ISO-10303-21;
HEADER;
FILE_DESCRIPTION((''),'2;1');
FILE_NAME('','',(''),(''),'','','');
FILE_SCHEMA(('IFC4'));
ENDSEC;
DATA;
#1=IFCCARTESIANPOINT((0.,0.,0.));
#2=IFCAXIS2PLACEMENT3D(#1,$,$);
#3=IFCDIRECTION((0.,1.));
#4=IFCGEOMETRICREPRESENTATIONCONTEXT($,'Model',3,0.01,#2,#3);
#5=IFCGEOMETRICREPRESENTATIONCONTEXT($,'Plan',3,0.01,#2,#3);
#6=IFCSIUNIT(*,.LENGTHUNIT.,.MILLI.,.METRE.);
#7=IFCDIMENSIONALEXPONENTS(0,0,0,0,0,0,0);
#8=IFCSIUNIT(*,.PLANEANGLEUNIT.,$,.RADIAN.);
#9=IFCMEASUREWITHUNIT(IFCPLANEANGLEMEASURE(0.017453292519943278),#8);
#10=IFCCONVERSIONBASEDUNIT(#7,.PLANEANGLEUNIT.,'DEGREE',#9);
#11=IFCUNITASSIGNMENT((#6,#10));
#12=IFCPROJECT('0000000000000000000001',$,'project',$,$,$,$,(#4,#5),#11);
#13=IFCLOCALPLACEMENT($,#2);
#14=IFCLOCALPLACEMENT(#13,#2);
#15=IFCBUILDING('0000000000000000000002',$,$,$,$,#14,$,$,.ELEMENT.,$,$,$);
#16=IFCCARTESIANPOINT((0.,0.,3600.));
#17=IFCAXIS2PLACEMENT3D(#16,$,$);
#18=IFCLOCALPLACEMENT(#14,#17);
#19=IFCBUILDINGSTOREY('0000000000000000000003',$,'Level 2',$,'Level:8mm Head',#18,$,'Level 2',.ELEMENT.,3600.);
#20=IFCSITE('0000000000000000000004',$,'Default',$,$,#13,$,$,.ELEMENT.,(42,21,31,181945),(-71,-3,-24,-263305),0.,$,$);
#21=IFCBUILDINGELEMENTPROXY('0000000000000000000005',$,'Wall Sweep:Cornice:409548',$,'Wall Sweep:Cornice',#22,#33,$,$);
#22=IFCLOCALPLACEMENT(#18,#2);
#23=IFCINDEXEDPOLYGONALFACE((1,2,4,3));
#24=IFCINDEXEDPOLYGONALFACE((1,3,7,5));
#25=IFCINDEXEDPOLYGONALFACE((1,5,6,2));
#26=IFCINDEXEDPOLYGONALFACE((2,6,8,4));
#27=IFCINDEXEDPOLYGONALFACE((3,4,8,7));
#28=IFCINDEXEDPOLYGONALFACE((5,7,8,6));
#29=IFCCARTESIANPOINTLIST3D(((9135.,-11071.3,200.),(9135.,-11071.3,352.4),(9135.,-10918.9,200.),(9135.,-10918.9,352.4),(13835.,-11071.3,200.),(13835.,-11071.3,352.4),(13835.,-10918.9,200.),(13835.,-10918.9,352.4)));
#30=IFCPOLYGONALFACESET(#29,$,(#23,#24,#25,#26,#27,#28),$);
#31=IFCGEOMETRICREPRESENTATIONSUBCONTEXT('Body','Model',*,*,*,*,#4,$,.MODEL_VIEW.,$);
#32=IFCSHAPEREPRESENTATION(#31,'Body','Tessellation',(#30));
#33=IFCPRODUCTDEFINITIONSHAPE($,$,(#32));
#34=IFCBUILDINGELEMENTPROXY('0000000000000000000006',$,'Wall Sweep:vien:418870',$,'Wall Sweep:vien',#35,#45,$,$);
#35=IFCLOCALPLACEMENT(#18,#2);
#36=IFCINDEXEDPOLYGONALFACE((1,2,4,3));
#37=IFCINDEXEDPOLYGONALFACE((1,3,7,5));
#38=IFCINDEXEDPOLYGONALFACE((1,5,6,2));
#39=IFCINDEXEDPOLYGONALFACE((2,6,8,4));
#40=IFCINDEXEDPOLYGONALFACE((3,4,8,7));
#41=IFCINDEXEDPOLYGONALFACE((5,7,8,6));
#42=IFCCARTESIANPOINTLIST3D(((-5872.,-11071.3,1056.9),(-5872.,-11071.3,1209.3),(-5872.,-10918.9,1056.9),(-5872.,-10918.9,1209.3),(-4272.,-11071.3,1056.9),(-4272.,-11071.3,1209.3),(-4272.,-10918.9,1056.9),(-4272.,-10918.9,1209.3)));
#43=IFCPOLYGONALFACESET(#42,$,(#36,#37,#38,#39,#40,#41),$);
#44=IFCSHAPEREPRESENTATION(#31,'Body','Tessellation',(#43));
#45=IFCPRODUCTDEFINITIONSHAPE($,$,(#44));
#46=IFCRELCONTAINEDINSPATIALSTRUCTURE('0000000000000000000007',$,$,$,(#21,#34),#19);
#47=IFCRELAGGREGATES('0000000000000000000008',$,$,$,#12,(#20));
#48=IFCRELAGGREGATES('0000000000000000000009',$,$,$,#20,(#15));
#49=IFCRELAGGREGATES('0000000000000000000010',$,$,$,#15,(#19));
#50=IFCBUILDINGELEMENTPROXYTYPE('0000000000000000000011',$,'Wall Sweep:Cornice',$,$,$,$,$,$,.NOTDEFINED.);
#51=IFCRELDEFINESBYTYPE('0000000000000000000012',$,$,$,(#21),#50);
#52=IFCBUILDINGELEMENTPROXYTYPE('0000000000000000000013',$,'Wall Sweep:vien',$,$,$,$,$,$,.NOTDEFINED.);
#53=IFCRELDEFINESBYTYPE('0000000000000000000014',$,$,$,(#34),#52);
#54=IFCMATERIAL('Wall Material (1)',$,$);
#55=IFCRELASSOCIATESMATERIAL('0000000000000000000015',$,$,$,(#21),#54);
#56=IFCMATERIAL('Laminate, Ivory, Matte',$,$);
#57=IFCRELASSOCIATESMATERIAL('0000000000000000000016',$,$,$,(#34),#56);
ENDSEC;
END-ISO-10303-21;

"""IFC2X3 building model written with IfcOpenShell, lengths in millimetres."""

from ifc_helpers import new_model, entity, si_unit, converted_unit, direction, frame, frame_2d, origin, origin_2d_with_axis, place, context, subcontext, project, spatial, rectangle, extrude, material, type_object, element, save


model = new_model("IFC2X3")

# Units and contexts
model_context = context("Model", 3, precision=0.01, world=origin(), true_north=direction((0.0, 1.0)))
plan_context = context("Plan", 3, precision=0.01, world=origin(), true_north=direction((0.0, 1.0)))
body_context = subcontext(model_context, "Body", "Model", "MODEL_VIEW")
ifc_project = project(units=[si_unit("LENGTHUNIT", "METRE", prefix="MILLI"), converted_unit("PLANEANGLEUNIT", "DEGREE", entity("IfcPlaneAngleMeasure", 0.017453292519943278), si_unit("PLANEANGLEUNIT", "RADIAN"), dimensions=[0, 0, 0, 0, 0, 0, 0])], contexts=[model_context, plan_context])

# Site, building, storey
site_placement = place(None, origin())
site = spatial("IfcSite", under=ifc_project, at=site_placement, Name="Default", CompositionType="ELEMENT", RefLatitude=(42, 21, 31, 181945), RefLongitude=(-71, -3, -24, -263305), RefElevation=0.0)
building_placement = place(site_placement, origin())
building = spatial("IfcBuilding", under=site, at=building_placement, CompositionType="ELEMENT")
storey_placement = place(building_placement, frame((0.0, 0.0, 3600.0)))
storey = spatial("IfcBuildingStorey", under=building, at=storey_placement, Name="Level 2", ObjectType="Level:8mm Head", LongName="Level 2", CompositionType="ELEMENT", Elevation=3600.0)

# Building element proxies
ifc_material_1 = material(Name="Wall Material (1)")
building_element_proxy_type_1 = type_object("IfcBuildingElementProxyType", Name="Wall Sweep:Cornice", PredefinedType="NOTDEFINED")
proxy_1_placement = place(storey_placement, origin())
element("IfcBuildingElementProxy", 1, at=proxy_1_placement, inside=storey, type_object=building_element_proxy_type_1, material=ifc_material_1, Name="Wall Sweep:Cornice:409548", ObjectType="Wall Sweep:Cornice", context=body_context, shape_type="SweptSolid", body=[
    extrude(rectangle(XDim=4700.0, YDim=152.4, at=frame_2d((0.0, 0.0), x_axis=(1.0, 0.0))), frame((11485.0, -10995.1, 200.0)), (0.0, 0.0, 1.0), 152.4),
])
ifc_material_2 = material(Name="Laminate, Ivory, Matte")
building_element_proxy_type_2 = type_object("IfcBuildingElementProxyType", Name="Wall Sweep:vien", PredefinedType="NOTDEFINED")
proxy_2_placement = place(storey_placement, origin())
element("IfcBuildingElementProxy", 2, at=proxy_2_placement, inside=storey, type_object=building_element_proxy_type_2, material=ifc_material_2, Name="Wall Sweep:vien:418870", ObjectType="Wall Sweep:vien", context=body_context, shape_type="SweptSolid", body=[
    extrude(rectangle(XDim=1600.0, YDim=152.4, at=origin_2d_with_axis()), frame((-5072.0, -10995.1, 1056.9)), (0.0, 0.0, 1.0), 152.4),
])

save(model, "model.ifc")
